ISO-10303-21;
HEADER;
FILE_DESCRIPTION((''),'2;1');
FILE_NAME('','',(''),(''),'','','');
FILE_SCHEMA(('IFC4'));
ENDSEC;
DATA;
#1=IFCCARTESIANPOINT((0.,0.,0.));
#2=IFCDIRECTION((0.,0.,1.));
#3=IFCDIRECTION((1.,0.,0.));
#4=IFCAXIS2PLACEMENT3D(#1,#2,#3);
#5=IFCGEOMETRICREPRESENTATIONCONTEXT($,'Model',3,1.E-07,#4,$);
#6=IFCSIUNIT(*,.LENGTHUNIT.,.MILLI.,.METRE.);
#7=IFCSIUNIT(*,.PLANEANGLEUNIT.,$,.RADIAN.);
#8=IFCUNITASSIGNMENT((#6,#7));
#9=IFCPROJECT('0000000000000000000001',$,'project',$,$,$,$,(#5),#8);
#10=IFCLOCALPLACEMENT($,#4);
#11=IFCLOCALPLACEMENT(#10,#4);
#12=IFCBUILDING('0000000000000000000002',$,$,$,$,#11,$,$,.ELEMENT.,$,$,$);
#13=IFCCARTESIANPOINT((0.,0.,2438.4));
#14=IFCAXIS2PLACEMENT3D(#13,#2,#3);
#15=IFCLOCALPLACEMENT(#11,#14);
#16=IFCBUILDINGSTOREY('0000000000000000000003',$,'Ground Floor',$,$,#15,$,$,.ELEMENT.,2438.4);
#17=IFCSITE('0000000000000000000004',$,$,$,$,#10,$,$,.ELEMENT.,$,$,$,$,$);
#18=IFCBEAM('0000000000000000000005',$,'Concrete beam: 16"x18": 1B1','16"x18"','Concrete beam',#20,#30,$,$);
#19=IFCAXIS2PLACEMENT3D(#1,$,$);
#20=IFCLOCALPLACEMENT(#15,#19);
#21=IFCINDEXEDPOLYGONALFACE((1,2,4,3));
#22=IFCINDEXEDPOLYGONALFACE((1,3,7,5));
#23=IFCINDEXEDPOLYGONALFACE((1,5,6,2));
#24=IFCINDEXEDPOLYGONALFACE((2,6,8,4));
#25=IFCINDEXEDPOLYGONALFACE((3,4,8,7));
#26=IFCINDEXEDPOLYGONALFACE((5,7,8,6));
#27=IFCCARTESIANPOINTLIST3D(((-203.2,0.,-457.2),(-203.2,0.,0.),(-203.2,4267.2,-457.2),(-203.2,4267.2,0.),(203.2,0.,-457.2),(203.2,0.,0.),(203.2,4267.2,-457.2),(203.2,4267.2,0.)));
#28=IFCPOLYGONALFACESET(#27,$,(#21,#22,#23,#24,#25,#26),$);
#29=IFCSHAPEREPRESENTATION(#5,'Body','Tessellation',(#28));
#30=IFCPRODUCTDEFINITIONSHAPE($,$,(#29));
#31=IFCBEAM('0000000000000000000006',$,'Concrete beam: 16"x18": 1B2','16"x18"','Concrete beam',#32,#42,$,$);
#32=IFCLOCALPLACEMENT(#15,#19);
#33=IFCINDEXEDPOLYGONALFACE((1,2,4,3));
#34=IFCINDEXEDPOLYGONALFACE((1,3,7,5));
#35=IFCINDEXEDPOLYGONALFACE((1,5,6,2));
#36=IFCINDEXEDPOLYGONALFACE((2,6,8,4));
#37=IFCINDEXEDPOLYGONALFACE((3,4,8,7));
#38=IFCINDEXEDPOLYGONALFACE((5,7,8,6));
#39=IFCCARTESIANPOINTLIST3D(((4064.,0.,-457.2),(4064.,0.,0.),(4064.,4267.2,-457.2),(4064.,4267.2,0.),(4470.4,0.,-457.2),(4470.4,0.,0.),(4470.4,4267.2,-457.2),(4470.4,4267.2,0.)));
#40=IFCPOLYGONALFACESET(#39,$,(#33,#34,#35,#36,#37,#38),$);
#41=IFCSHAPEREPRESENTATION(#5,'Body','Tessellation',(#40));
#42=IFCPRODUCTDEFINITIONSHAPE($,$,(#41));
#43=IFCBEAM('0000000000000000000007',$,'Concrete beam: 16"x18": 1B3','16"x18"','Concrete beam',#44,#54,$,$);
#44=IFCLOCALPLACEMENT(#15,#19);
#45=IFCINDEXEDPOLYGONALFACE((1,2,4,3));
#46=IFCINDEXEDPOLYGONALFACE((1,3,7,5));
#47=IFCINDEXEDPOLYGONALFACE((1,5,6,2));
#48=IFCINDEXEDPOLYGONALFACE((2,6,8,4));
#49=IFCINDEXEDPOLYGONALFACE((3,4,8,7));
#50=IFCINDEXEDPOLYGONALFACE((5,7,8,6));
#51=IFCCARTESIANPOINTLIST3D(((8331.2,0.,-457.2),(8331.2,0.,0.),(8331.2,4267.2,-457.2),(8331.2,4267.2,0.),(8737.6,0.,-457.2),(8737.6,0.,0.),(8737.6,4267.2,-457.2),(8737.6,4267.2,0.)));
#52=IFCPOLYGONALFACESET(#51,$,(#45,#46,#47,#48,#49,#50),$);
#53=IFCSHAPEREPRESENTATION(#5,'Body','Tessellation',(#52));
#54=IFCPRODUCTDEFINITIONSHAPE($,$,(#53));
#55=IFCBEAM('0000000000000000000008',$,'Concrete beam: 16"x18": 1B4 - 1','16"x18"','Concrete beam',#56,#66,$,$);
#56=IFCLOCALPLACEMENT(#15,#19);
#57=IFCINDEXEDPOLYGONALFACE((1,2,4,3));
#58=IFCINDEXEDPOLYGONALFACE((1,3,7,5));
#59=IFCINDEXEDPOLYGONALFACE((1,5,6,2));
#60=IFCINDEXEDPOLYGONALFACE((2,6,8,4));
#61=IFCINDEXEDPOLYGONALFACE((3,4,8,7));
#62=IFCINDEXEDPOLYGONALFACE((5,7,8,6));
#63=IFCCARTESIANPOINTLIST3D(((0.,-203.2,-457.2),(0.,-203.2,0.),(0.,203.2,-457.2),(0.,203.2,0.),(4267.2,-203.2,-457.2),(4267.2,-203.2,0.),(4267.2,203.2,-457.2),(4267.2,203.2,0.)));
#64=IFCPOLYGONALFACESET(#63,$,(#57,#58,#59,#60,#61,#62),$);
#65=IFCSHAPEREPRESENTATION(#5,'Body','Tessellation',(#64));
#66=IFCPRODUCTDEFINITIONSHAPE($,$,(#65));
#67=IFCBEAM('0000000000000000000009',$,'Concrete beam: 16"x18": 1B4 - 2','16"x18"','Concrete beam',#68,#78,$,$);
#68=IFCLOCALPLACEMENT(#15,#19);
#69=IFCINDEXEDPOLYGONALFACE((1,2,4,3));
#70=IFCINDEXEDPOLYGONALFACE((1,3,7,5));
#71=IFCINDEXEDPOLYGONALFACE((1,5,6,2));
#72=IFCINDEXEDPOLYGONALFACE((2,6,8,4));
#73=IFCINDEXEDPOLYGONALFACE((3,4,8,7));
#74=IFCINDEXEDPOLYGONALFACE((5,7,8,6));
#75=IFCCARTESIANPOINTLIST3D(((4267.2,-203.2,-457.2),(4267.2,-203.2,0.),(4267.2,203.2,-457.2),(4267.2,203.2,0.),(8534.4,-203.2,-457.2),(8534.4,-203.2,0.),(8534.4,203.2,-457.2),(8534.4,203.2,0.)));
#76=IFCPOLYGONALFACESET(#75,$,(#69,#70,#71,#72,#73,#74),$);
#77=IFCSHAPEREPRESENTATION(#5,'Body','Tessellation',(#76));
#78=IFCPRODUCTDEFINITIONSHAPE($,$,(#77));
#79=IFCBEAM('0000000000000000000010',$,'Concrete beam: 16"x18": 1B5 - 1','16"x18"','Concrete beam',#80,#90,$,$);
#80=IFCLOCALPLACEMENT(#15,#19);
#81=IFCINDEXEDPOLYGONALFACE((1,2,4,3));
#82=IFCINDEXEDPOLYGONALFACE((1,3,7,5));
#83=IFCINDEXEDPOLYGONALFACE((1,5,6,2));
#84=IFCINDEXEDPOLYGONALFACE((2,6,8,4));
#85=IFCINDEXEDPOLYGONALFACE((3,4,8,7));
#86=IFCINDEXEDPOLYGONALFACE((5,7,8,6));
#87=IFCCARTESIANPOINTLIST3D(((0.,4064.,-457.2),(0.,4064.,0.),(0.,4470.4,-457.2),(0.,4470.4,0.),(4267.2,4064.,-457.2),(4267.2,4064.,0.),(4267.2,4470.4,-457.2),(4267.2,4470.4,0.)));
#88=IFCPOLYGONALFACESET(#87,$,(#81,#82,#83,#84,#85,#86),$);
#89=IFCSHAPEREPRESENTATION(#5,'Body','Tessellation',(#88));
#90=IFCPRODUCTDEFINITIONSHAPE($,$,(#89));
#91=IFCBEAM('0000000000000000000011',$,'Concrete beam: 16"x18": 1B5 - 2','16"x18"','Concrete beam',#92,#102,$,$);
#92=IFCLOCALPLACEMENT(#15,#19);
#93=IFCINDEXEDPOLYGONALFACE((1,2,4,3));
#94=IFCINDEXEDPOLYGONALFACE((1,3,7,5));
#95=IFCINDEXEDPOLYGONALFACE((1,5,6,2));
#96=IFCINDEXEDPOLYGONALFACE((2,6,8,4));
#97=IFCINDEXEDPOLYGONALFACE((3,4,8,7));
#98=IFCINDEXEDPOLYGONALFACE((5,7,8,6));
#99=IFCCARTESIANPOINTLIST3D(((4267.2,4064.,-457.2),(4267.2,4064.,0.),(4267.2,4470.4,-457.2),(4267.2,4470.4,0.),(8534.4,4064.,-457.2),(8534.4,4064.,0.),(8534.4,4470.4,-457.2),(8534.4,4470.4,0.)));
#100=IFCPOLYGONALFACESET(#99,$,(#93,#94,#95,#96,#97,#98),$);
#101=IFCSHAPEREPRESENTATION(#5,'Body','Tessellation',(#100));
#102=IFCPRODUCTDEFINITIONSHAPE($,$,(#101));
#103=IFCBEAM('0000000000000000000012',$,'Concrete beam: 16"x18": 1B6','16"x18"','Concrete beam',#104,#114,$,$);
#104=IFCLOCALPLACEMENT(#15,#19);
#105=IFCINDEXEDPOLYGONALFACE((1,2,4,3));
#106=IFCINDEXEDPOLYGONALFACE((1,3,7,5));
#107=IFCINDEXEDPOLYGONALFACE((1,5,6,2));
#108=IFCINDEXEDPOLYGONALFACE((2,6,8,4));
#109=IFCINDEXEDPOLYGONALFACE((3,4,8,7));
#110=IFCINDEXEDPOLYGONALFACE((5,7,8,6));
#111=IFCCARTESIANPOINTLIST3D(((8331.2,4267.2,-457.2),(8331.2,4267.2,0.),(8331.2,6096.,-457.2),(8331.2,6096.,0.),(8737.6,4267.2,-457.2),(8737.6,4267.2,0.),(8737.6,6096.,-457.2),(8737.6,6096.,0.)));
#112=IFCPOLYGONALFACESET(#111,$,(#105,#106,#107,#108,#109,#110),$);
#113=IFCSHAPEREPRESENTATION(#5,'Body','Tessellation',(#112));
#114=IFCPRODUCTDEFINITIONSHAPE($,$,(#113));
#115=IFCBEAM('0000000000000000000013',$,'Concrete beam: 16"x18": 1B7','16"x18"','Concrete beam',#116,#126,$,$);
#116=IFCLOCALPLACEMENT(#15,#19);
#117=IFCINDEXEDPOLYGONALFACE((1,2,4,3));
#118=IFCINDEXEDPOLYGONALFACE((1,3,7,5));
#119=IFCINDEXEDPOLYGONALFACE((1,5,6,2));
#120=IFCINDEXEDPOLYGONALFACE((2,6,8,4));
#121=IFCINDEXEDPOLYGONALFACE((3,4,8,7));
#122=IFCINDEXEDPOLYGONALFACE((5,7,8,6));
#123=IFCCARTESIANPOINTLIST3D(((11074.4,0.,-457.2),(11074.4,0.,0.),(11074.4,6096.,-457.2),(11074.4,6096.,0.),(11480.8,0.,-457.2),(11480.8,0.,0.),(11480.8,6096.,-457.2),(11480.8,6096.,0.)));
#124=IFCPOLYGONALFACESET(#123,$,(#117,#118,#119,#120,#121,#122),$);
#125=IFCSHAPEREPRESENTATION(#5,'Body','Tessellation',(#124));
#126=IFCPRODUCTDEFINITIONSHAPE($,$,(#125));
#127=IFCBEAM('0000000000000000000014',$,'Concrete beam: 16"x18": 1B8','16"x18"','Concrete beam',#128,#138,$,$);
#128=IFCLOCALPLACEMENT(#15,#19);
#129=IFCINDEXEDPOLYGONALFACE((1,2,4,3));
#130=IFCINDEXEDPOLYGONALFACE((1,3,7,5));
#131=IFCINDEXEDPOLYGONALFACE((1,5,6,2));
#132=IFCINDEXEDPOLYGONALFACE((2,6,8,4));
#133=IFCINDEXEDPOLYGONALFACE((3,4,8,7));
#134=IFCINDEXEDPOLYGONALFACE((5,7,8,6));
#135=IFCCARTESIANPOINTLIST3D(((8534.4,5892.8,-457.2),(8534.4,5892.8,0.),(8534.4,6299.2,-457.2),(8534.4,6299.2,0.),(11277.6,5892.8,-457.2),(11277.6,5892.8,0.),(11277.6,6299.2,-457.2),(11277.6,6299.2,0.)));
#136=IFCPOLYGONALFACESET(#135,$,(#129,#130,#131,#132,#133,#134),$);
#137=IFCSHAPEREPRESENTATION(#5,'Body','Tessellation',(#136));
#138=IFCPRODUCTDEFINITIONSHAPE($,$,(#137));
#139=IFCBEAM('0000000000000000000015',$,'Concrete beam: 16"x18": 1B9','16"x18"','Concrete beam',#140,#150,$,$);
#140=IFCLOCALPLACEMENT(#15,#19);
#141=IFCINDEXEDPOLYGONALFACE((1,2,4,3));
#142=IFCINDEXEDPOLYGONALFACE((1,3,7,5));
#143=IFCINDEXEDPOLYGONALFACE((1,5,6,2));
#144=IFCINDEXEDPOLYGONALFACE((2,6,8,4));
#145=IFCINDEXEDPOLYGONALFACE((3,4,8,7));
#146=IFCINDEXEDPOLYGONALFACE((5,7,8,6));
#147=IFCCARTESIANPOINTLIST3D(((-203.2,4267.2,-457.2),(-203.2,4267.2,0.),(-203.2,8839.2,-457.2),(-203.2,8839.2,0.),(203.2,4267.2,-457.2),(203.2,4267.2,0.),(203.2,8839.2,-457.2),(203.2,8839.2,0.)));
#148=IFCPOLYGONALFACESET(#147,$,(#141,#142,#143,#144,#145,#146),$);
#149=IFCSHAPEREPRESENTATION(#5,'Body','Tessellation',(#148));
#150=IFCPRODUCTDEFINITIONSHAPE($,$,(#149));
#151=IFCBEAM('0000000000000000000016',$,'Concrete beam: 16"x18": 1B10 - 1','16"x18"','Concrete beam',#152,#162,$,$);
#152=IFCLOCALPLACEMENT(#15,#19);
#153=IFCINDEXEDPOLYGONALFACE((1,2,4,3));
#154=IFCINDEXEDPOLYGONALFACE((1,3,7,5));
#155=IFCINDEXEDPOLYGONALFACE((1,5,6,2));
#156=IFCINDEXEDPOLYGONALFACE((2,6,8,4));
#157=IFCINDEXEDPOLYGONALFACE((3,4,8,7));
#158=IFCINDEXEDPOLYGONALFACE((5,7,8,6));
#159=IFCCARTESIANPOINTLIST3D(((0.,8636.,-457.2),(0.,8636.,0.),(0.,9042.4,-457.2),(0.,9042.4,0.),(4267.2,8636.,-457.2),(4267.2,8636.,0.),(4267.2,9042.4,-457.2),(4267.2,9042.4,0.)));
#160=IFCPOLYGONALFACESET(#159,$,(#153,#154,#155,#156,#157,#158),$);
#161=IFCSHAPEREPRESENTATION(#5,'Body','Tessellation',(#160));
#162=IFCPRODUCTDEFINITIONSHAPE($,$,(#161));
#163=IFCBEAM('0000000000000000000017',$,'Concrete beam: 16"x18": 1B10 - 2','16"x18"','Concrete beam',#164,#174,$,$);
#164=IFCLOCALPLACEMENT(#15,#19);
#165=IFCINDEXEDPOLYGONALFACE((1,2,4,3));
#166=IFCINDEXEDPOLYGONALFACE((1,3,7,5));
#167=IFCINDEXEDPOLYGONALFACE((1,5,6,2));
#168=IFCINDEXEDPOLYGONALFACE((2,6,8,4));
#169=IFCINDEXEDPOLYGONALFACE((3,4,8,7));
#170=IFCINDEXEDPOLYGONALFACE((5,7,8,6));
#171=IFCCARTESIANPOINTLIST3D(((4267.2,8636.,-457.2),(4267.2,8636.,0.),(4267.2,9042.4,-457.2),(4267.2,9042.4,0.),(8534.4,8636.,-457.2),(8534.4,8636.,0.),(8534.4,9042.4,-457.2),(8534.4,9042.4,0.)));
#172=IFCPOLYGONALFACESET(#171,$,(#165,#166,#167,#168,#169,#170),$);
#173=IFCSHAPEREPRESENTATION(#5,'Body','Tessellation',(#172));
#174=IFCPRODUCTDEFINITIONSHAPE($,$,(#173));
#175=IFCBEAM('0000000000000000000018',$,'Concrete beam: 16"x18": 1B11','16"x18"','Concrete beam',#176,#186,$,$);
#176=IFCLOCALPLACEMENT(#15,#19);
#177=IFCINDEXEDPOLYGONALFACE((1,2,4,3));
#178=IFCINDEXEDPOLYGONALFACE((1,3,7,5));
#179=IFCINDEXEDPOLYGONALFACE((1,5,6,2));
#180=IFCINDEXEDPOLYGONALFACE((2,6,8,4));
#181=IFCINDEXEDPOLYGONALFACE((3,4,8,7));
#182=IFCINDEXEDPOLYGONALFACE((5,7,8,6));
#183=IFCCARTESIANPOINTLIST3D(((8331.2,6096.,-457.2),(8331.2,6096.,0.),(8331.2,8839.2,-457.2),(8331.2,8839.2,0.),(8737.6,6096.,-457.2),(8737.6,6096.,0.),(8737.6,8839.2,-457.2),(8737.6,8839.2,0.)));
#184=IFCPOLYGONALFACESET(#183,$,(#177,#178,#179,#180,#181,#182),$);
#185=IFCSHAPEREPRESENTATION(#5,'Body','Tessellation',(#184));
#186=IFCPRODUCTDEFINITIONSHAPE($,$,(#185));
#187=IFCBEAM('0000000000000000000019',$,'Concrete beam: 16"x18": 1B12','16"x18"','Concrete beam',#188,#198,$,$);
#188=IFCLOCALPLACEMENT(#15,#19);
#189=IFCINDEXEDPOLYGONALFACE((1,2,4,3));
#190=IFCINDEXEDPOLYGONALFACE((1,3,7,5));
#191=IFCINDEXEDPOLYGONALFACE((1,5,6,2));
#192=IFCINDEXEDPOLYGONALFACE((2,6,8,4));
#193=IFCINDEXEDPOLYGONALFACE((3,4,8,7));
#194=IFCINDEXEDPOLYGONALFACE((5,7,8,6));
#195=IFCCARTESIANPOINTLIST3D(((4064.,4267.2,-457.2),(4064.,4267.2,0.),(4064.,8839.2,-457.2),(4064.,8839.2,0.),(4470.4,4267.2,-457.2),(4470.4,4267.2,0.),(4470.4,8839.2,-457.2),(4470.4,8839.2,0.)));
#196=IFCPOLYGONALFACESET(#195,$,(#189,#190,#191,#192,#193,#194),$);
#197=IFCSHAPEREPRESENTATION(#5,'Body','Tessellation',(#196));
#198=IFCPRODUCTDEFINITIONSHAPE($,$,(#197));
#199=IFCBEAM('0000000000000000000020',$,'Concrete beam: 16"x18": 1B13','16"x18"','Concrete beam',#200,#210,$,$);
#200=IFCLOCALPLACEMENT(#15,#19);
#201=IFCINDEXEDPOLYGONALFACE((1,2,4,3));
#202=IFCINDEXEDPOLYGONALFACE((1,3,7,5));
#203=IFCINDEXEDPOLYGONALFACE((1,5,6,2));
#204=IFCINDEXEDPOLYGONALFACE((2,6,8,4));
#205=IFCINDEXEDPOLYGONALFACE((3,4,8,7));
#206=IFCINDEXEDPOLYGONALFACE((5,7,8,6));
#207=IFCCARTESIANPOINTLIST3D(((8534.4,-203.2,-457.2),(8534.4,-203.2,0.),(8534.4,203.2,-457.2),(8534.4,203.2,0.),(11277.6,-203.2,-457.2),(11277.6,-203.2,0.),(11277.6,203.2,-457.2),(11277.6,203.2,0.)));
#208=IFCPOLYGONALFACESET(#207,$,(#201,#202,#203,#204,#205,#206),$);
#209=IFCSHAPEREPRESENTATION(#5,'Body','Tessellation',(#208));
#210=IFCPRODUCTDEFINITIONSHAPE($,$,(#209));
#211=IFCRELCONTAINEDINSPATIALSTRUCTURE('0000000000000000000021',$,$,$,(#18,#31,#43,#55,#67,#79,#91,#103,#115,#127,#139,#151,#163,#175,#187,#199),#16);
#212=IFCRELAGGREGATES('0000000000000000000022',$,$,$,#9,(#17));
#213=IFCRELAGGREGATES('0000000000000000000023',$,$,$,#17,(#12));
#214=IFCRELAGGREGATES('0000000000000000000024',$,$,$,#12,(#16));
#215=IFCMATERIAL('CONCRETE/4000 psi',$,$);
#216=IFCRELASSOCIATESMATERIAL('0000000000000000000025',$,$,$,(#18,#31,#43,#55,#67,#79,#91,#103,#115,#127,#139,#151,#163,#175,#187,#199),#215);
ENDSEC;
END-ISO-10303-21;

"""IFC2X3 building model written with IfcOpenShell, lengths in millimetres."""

from ifc_helpers import new_model, si_unit, frame, origin_with_axes, origin_2d_with_axis, place, context, project, spatial, rectangle, extrude, material, element, save


model = new_model("IFC2X3")

# Units and contexts
model_context = context("Model", 3, precision=1e-07, world=origin_with_axes())
ifc_project = project(units=[si_unit("LENGTHUNIT", "METRE", prefix="MILLI"), si_unit("PLANEANGLEUNIT", "RADIAN")], contexts=[model_context])

# Site, building, storey
site_placement = place(None, origin_with_axes())
site = spatial("IfcSite", under=ifc_project, at=site_placement, CompositionType="ELEMENT")
building_placement = place(site_placement, origin_with_axes())
building = spatial("IfcBuilding", under=site, at=building_placement, CompositionType="ELEMENT")
storey_placement = place(building_placement, frame((0.0, 0.0, 2438.4), z_axis=(0.0, 0.0, 1.0), x_axis=(1.0, 0.0, 0.0)))
storey = spatial("IfcBuildingStorey", under=building, at=storey_placement, Name="Ground Floor", CompositionType="ELEMENT", Elevation=2438.4)

# Beams
ifc_material = material(Name="CONCRETE/4000 psi")
for number, where, z_axis, x_axis, name in (
    (1, (0.0, 0.0, 2438.4), (0.0, 0.0, 1.0), (0.0, 1.0, 0.0), "Concrete beam: 16\"x18\": 1B1"),
    (2, (4267.2, 0.0, 2438.4), (0.0, 0.0, 1.0), (0.0, 1.0, 0.0), "Concrete beam: 16\"x18\": 1B2"),
    (3, (8534.4, 0.0, 2438.4), (0.0, 0.0, 1.0), (0.0, 1.0, 0.0), "Concrete beam: 16\"x18\": 1B3"),
    (4, (0.0, 0.0, 2438.4), (0.0, 0.0, 1.0), (1.0, 0.0, 0.0), "Concrete beam: 16\"x18\": 1B4 - 1"),
    (5, (4267.2, 0.0, 2438.4), (0.0, 0.0, 1.0), (1.0, 0.0, 0.0), "Concrete beam: 16\"x18\": 1B4 - 2"),
    (6, (0.0, 4267.2, 2438.4), (0.0, 0.0, 1.0), (1.0, 0.0, 0.0), "Concrete beam: 16\"x18\": 1B5 - 1"),
    (7, (4267.2, 4267.2, 2438.4), (0.0, 0.0, 1.0), (1.0, 0.0, 0.0), "Concrete beam: 16\"x18\": 1B5 - 2"),
):
    element("IfcBeam", number, at=place(building_placement, frame(where, z_axis=z_axis, x_axis=x_axis)), inside=storey, material=ifc_material, Name=name, Description="16\"x18\"", ObjectType="Concrete beam", context=model_context, shape_type="SweptSolid", body=[
        extrude(rectangle(XDim=406.4, YDim=457.2, at=origin_2d_with_axis()), frame((4267.2, 0.0, -228.6), z_axis=(-1.0, 0.0, 0.0), x_axis=(0.0, -1.0, 0.0)), (0.0, 0.0, 1.0), 4267.2),
    ])
beam_1_placement = place(building_placement, frame((8534.4, 4267.2, 2438.4), z_axis=(0.0, 0.0, 1.0), x_axis=(0.0, 1.0, 0.0)))
element("IfcBeam", 8, at=beam_1_placement, inside=storey, material=ifc_material, Name="Concrete beam: 16\"x18\": 1B6", Description="16\"x18\"", ObjectType="Concrete beam", context=model_context, shape_type="SweptSolid", body=[
    extrude(rectangle(XDim=406.4, YDim=457.2, at=origin_2d_with_axis()), frame((1828.8, 0.0, -228.6), z_axis=(-1.0, 0.0, 0.0), x_axis=(0.0, -1.0, 0.0)), (0.0, 0.0, 1.0), 1828.8),
])
beam_2_placement = place(building_placement, frame((11277.6, 0.0, 2438.4), z_axis=(0.0, 0.0, 1.0), x_axis=(0.0, 1.0, 0.0)))
element("IfcBeam", 9, at=beam_2_placement, inside=storey, material=ifc_material, Name="Concrete beam: 16\"x18\": 1B7", Description="16\"x18\"", ObjectType="Concrete beam", context=model_context, shape_type="SweptSolid", body=[
    extrude(rectangle(XDim=406.4, YDim=457.2, at=origin_2d_with_axis()), frame((6096.0, 0.0, -228.6), z_axis=(-1.0, 0.0, 0.0), x_axis=(0.0, -1.0, 0.0)), (0.0, 0.0, 1.0), 6096.0),
])
beam_3_placement = place(building_placement, frame((8534.4, 6096.0, 2438.4), z_axis=(0.0, 0.0, 1.0), x_axis=(1.0, 0.0, 0.0)))
element("IfcBeam", 10, at=beam_3_placement, inside=storey, material=ifc_material, Name="Concrete beam: 16\"x18\": 1B8", Description="16\"x18\"", ObjectType="Concrete beam", context=model_context, shape_type="SweptSolid", body=[
    extrude(rectangle(XDim=406.4, YDim=457.2, at=origin_2d_with_axis()), frame((2743.2, 0.0, -228.6), z_axis=(-1.0, 0.0, 0.0), x_axis=(0.0, -1.0, 0.0)), (0.0, 0.0, 1.0), 2743.2),
])
beam_4_placement = place(building_placement, frame((0.0, 4267.2, 2438.4), z_axis=(0.0, 0.0, 1.0), x_axis=(0.0, 1.0, 0.0)))
element("IfcBeam", 11, at=beam_4_placement, inside=storey, material=ifc_material, Name="Concrete beam: 16\"x18\": 1B9", Description="16\"x18\"", ObjectType="Concrete beam", context=model_context, shape_type="SweptSolid", body=[
    extrude(rectangle(XDim=406.4, YDim=457.2, at=origin_2d_with_axis()), frame((4572.0, 0.0, -228.6), z_axis=(-1.0, 0.0, 0.0), x_axis=(0.0, -1.0, 0.0)), (0.0, 0.0, 1.0), 4572.0),
])
for number, where, z_axis, x_axis, name in (
    (12, (0.0, 8839.2, 2438.4), (0.0, 0.0, 1.0), (1.0, 0.0, 0.0), "Concrete beam: 16\"x18\": 1B10 - 1"),
    (13, (4267.2, 8839.2, 2438.4), (0.0, 0.0, 1.0), (1.0, 0.0, 0.0), "Concrete beam: 16\"x18\": 1B10 - 2"),
):
    element("IfcBeam", number, at=place(building_placement, frame(where, z_axis=z_axis, x_axis=x_axis)), inside=storey, material=ifc_material, Name=name, Description="16\"x18\"", ObjectType="Concrete beam", context=model_context, shape_type="SweptSolid", body=[
        extrude(rectangle(XDim=406.4, YDim=457.2, at=origin_2d_with_axis()), frame((4267.2, 0.0, -228.6), z_axis=(-1.0, 0.0, 0.0), x_axis=(0.0, -1.0, 0.0)), (0.0, 0.0, 1.0), 4267.2),
    ])
beam_5_placement = place(building_placement, frame((8534.4, 6096.0, 2438.4), z_axis=(0.0, 0.0, 1.0), x_axis=(0.0, 1.0, 0.0)))
element("IfcBeam", 14, at=beam_5_placement, inside=storey, material=ifc_material, Name="Concrete beam: 16\"x18\": 1B11", Description="16\"x18\"", ObjectType="Concrete beam", context=model_context, shape_type="SweptSolid", body=[
    extrude(rectangle(XDim=406.4, YDim=457.2, at=origin_2d_with_axis()), frame((2743.2, 0.0, -228.6), z_axis=(-1.0, 0.0, 0.0), x_axis=(0.0, -1.0, 0.0)), (0.0, 0.0, 1.0), 2743.2),
])
beam_6_placement = place(building_placement, frame((4267.2, 4267.2, 2438.4), z_axis=(0.0, 0.0, 1.0), x_axis=(0.0, 1.0, 0.0)))
element("IfcBeam", 15, at=beam_6_placement, inside=storey, material=ifc_material, Name="Concrete beam: 16\"x18\": 1B12", Description="16\"x18\"", ObjectType="Concrete beam", context=model_context, shape_type="SweptSolid", body=[
    extrude(rectangle(XDim=406.4, YDim=457.2, at=origin_2d_with_axis()), frame((4572.0, 0.0, -228.6), z_axis=(-1.0, 0.0, 0.0), x_axis=(0.0, -1.0, 0.0)), (0.0, 0.0, 1.0), 4572.0),
])
beam_7_placement = place(building_placement, frame((8534.4, 0.0, 2438.4), z_axis=(0.0, 0.0, 1.0), x_axis=(1.0, 0.0, 0.0)))
element("IfcBeam", 16, at=beam_7_placement, inside=storey, material=ifc_material, Name="Concrete beam: 16\"x18\": 1B13", Description="16\"x18\"", ObjectType="Concrete beam", context=model_context, shape_type="SweptSolid", body=[
    extrude(rectangle(XDim=406.4, YDim=457.2, at=origin_2d_with_axis()), frame((2743.2, 0.0, -228.6), z_axis=(-1.0, 0.0, 0.0), x_axis=(0.0, -1.0, 0.0)), (0.0, 0.0, 1.0), 2743.2),
])

save(model, "model.ifc")
